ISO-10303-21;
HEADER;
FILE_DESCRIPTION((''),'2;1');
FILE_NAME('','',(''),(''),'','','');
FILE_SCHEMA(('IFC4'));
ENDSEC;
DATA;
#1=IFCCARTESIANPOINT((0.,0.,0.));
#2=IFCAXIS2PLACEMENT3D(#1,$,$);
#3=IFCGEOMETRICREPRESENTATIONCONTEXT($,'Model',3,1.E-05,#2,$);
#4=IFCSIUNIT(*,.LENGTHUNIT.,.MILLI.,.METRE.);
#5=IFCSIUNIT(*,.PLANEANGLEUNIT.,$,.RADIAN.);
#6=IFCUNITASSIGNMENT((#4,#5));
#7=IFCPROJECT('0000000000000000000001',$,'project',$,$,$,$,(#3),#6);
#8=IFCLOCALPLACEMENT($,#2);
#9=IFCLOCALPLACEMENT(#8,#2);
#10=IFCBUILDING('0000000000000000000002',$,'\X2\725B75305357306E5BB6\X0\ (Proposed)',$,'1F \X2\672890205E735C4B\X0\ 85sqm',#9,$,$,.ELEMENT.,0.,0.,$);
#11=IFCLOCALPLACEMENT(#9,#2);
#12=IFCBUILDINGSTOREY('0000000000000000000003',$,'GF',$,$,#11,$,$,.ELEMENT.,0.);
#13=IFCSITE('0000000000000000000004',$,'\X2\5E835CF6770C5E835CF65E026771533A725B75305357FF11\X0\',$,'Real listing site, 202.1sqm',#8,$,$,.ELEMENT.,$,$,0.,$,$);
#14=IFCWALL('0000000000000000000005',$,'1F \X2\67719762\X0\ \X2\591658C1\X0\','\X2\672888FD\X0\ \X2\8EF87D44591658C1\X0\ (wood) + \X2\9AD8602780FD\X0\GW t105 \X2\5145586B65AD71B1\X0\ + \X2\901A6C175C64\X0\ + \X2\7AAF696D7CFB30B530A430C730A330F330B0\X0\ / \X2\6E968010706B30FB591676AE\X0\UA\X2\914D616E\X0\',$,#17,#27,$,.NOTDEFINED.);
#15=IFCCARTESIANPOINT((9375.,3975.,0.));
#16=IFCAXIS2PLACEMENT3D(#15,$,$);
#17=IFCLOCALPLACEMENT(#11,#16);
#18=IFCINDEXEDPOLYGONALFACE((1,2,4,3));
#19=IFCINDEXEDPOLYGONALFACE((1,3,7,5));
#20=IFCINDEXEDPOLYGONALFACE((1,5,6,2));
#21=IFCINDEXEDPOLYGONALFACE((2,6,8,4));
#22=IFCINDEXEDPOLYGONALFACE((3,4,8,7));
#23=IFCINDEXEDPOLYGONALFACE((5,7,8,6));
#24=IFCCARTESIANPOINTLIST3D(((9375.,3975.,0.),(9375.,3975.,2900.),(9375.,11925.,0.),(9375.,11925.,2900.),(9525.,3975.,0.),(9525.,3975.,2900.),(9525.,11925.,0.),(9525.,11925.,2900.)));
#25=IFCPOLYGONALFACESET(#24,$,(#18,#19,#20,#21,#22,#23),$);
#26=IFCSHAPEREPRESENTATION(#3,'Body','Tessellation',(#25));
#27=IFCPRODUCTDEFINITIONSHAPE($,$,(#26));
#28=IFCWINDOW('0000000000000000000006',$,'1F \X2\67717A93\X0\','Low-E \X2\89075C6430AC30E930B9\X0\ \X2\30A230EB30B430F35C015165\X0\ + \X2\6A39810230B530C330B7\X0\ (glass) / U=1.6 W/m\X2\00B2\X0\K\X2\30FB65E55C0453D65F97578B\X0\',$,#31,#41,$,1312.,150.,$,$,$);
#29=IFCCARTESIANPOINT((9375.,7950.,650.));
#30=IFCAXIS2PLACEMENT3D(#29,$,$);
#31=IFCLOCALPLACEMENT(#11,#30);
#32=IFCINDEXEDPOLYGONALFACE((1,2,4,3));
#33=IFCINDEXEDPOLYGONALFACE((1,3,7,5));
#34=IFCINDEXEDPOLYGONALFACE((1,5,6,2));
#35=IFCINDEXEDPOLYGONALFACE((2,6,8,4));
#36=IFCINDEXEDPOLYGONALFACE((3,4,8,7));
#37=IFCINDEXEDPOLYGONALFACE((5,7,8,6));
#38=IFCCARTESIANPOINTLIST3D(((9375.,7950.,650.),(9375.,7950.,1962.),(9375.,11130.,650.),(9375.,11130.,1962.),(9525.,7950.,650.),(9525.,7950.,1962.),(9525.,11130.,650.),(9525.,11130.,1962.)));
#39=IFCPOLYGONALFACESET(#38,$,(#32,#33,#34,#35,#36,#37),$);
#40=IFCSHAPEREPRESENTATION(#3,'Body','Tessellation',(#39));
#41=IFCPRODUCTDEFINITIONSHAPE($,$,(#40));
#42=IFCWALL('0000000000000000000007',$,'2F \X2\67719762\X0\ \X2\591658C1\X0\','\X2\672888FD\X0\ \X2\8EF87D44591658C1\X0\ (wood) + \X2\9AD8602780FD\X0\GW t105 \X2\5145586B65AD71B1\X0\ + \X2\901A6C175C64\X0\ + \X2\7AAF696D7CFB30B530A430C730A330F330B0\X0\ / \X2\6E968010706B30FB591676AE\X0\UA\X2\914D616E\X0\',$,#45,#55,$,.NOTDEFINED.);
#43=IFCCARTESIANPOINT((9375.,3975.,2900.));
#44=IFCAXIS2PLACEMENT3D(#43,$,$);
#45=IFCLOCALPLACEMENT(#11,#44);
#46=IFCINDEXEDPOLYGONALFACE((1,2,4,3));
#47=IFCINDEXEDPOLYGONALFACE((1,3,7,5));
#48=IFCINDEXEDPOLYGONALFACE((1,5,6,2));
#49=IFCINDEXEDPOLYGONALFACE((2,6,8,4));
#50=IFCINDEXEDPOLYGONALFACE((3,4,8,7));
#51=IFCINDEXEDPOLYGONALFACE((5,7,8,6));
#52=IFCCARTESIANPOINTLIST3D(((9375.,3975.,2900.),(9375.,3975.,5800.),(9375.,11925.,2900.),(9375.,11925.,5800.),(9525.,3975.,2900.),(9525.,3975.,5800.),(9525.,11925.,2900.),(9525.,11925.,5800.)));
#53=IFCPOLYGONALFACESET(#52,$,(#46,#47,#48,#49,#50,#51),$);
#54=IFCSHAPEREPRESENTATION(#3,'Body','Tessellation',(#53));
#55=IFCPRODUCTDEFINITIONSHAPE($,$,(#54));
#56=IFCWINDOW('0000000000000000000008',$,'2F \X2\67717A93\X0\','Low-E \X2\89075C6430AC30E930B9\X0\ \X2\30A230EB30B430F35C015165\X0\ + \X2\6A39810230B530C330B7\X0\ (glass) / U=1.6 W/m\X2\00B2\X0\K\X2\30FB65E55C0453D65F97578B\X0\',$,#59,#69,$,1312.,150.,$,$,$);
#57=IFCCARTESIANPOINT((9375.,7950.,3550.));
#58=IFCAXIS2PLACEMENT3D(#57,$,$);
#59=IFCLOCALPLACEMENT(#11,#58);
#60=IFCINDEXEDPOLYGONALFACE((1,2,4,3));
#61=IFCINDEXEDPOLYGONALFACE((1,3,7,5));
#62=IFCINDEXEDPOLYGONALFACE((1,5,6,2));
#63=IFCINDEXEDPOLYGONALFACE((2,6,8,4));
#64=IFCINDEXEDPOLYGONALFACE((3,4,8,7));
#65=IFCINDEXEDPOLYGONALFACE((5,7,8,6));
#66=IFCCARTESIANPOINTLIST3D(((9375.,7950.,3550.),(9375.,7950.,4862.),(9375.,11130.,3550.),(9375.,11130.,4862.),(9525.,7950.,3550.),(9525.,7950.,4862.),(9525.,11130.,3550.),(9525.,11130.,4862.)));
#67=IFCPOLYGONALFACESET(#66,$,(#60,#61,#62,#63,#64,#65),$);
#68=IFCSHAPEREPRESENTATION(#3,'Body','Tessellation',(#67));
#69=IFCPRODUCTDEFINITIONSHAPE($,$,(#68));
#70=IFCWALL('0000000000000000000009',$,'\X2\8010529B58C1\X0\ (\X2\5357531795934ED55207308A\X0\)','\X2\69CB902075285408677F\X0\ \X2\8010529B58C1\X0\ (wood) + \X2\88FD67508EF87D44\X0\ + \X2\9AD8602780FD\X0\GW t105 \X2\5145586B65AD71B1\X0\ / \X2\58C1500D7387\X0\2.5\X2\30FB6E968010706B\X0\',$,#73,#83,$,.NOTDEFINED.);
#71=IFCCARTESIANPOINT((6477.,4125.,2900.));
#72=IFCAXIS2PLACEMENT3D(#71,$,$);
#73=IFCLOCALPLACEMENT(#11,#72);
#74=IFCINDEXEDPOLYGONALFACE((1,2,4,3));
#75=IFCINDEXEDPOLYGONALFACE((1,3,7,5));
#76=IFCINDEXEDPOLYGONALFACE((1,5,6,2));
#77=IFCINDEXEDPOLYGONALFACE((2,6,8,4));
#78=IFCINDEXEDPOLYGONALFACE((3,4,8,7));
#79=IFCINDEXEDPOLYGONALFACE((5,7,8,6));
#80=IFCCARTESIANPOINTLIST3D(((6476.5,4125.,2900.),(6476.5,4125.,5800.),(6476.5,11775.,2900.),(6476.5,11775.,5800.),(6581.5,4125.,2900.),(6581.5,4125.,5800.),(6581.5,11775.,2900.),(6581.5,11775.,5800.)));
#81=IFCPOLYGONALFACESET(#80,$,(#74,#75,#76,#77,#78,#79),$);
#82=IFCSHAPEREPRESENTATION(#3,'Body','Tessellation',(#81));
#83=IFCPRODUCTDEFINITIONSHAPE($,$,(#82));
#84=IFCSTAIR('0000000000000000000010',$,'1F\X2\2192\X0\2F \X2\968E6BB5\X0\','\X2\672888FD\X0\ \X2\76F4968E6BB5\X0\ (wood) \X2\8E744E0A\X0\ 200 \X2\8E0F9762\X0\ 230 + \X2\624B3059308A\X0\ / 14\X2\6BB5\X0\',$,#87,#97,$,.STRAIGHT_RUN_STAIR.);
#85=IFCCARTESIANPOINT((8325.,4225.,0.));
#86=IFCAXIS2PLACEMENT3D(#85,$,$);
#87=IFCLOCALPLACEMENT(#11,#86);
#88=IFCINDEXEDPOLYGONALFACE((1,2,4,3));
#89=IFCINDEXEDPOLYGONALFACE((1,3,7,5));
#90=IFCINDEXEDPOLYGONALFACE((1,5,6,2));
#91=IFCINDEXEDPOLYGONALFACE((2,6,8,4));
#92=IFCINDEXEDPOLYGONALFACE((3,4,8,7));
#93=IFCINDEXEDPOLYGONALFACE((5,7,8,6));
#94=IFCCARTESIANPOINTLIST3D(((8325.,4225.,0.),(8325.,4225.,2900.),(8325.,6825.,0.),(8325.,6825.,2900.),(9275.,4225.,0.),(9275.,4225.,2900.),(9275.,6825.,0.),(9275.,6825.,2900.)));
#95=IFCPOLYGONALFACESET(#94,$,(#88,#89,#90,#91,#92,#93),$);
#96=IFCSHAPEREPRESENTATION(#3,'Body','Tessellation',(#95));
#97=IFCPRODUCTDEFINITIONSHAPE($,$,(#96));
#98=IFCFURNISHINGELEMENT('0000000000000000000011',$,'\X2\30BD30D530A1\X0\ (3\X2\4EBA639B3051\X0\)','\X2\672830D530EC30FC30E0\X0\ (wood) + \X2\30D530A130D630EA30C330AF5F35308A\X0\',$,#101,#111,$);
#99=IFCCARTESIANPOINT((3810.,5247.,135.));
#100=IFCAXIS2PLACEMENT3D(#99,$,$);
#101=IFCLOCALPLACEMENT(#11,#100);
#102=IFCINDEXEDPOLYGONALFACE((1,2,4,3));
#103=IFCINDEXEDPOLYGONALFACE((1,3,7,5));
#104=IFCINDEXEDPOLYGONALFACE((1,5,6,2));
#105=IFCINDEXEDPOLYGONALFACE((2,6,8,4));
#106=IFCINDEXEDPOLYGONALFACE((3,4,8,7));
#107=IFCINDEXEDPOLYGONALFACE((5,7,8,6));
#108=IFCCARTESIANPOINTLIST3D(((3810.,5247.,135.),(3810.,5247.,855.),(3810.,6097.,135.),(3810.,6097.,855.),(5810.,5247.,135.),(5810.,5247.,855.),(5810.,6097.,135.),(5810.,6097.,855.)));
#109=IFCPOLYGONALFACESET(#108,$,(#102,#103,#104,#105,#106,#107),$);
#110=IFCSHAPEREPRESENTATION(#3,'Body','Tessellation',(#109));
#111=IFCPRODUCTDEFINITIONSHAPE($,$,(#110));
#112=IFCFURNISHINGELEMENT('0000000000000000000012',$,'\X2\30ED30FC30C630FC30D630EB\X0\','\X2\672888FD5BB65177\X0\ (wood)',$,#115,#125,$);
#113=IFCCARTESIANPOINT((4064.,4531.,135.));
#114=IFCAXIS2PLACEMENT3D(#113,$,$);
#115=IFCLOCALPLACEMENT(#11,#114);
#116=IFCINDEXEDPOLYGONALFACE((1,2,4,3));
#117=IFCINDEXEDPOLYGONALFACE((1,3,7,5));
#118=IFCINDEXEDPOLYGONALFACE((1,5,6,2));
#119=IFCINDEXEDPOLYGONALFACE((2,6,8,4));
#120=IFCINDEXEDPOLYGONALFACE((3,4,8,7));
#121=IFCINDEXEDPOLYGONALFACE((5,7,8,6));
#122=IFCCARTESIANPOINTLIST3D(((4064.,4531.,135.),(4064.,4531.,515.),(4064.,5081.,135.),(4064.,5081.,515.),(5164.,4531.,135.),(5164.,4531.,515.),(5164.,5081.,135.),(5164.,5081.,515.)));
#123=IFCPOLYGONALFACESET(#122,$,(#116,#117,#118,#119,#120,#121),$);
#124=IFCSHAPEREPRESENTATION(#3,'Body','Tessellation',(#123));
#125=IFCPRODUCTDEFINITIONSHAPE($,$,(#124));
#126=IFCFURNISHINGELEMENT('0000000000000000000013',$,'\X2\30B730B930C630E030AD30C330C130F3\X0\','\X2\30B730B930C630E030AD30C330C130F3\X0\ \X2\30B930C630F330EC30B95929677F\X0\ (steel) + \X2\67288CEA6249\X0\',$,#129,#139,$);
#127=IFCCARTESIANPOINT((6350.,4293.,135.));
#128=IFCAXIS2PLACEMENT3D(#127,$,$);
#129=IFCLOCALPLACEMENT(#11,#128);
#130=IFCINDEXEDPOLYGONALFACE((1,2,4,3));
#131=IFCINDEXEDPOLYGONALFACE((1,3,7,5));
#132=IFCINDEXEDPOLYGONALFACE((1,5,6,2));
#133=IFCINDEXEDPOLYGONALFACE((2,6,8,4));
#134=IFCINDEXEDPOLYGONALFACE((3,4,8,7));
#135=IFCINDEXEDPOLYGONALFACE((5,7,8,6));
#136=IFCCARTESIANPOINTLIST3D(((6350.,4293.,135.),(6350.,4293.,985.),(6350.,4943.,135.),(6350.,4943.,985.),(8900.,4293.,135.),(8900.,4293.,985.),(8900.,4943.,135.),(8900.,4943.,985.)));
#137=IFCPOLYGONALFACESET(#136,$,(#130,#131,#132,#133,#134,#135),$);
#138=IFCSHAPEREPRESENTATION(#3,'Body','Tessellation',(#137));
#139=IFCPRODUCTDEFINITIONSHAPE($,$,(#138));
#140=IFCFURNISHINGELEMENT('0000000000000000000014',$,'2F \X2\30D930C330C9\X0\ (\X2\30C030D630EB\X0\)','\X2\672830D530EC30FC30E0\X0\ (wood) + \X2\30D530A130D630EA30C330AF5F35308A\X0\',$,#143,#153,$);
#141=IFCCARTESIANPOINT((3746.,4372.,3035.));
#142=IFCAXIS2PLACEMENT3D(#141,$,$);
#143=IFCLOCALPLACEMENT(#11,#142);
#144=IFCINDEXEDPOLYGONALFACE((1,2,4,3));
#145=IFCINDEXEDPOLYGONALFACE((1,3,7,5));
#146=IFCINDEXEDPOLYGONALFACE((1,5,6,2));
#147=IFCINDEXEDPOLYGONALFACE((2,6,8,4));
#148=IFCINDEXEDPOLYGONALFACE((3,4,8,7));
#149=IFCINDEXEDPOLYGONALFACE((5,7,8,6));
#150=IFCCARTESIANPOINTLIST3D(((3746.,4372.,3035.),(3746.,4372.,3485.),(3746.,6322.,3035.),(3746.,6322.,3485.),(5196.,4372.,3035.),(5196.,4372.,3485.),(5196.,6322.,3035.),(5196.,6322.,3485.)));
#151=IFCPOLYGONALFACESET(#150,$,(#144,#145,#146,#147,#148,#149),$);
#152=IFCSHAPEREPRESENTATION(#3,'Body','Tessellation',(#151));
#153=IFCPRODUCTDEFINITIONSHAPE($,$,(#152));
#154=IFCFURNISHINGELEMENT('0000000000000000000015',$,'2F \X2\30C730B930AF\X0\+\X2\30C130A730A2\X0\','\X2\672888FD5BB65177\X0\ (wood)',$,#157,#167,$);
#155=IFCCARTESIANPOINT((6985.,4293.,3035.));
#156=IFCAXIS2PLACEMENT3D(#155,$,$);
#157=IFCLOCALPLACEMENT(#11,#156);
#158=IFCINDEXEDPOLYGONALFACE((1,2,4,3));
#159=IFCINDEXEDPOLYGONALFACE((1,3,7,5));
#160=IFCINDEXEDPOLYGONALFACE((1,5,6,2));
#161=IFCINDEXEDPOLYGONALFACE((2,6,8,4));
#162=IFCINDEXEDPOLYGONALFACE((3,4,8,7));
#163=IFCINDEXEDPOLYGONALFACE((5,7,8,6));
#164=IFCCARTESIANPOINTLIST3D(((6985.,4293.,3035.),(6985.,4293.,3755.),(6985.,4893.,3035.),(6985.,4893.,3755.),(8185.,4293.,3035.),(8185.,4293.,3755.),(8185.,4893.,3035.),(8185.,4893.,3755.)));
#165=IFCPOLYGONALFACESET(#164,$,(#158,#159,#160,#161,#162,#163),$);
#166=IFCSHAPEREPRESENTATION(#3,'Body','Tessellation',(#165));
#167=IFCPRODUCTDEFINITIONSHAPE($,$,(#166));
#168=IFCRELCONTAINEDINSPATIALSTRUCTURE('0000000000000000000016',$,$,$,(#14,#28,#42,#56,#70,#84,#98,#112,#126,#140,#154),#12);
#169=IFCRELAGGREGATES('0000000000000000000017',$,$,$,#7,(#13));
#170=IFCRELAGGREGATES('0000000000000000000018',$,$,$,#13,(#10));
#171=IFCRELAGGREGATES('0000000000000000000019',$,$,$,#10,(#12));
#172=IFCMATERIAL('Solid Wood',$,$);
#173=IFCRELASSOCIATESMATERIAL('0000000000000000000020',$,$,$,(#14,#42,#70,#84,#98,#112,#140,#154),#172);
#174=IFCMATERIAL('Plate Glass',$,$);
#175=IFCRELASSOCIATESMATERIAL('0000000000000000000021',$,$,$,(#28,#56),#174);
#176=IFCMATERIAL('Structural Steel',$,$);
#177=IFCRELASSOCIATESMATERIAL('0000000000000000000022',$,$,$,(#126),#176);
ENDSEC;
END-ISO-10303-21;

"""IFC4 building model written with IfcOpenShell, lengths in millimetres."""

from ifc_helpers import new_model, si_unit, frame, frame_2d, origin, place, context, project, spatial, rectangle, extrude, material, element, fill, save


model = new_model("IFC4")

# Units and contexts
model_context = context("Model", 3, precision=1e-05, world=origin())
ifc_project = project(units=[si_unit("LENGTHUNIT", "METRE", prefix="MILLI"), si_unit("PLANEANGLEUNIT", "RADIAN")], contexts=[model_context])

# Site, building, storey
site_placement = place(None, origin())
site = spatial("IfcSite", under=ifc_project, at=site_placement, Name="広島県広島市東区牛田南１", ObjectType="Real listing site, 202.1sqm", CompositionType="ELEMENT", RefElevation=0.0)
building_placement = place(site_placement, origin())
building = spatial("IfcBuilding", under=site, at=building_placement, Name="牛田南の家 (Proposed)", ObjectType="1F 木造平屋 85sqm", CompositionType="ELEMENT", ElevationOfRefHeight=0.0, ElevationOfTerrain=0.0)
storey_placement = place(building_placement, origin())
storey = spatial("IfcBuildingStorey", under=building, at=storey_placement, Name="GF", CompositionType="ELEMENT", Elevation=0.0)

# Wall, opening, window
ifc_material_1 = material(Name="Solid Wood")
wall_1_placement = place(storey_placement, frame((9375.0, 3975.0, 0.0)))
wall_1 = element("IfcWall", 1, at=wall_1_placement, inside=storey, material=ifc_material_1, Name="1F 東面 外壁", Description="木製 軸組外壁 (wood) + 高性能GW t105 充填断熱 + 通気層 + 窯業系サイディング / 準耐火・外皮UA配慮", PredefinedType="NOTDEFINED", context=model_context, shape_type="SweptSolid", body=[
    extrude(rectangle(XDim=150.0, YDim=7950.0, at=frame_2d((75.0, 3975.0))), frame((9375.0, 3975.0, 0.0)), (0.0, 0.0, 1.0), 2900.0),
])
opening_1_placement = place(storey_placement, frame((9375.0, 7950.0, 650.0)))
opening_1 = element("IfcOpeningElement", 2, at=opening_1_placement, cuts=wall_1, PredefinedType="NOTDEFINED", context=model_context, shape_type="SweptSolid", body=[
    extrude(rectangle(XDim=150.0, YDim=3180.0, at=frame_2d((75.0, 1590.0))), frame((9375.0, 7950.0, 650.0)), (0.0, 0.0, 1.0), 1312.0),
])
ifc_material_2 = material(Name="Plate Glass")
window_1_placement = place(storey_placement, frame((9375.0, 7950.0, 650.0)))
window_1 = element("IfcWindow", 3, at=window_1_placement, inside=storey, material=ifc_material_2, Name="1F 東窓", Description="Low-E 複層ガラス アルゴン封入 + 樹脂サッシ (glass) / U=1.6 W/m²K・日射取得型", OverallHeight=1312.0, OverallWidth=150.0, context=model_context, shape_type="SweptSolid", body=[
    extrude(rectangle(XDim=150.0, YDim=3180.0, at=frame_2d((75.0, 1590.0))), frame((9375.0, 7950.0, 650.0)), (0.0, 0.0, 1.0), 1312.0),
])
fill(opening_1, window_1)

# Wall, opening, window
wall_2_placement = place(storey_placement, frame((9375.0, 3975.0, 2900.0)))
wall_2 = element("IfcWall", 4, at=wall_2_placement, inside=storey, material=ifc_material_1, Name="2F 東面 外壁", Description="木製 軸組外壁 (wood) + 高性能GW t105 充填断熱 + 通気層 + 窯業系サイディング / 準耐火・外皮UA配慮", PredefinedType="NOTDEFINED", context=model_context, shape_type="SweptSolid", body=[
    extrude(rectangle(XDim=150.0, YDim=7950.0, at=frame_2d((75.0, 3975.0))), frame((9375.0, 3975.0, 2900.0)), (0.0, 0.0, 1.0), 2900.0),
])
opening_2_placement = place(storey_placement, frame((9375.0, 7950.0, 3550.0)))
opening_2 = element("IfcOpeningElement", 5, at=opening_2_placement, cuts=wall_2, PredefinedType="NOTDEFINED", context=model_context, shape_type="SweptSolid", body=[
    extrude(rectangle(XDim=150.0, YDim=3180.0, at=frame_2d((75.0, 1590.0))), frame((9375.0, 7950.0, 3550.0)), (0.0, 0.0, 1.0), 1312.0),
])
window_2_placement = place(storey_placement, frame((9375.0, 7950.0, 3550.0)))
window_2 = element("IfcWindow", 6, at=window_2_placement, inside=storey, material=ifc_material_2, Name="2F 東窓", Description="Low-E 複層ガラス アルゴン封入 + 樹脂サッシ (glass) / U=1.6 W/m²K・日射取得型", OverallHeight=1312.0, OverallWidth=150.0, context=model_context, shape_type="SweptSolid", body=[
    extrude(rectangle(XDim=150.0, YDim=3180.0, at=frame_2d((75.0, 1590.0))), frame((9375.0, 7950.0, 3550.0)), (0.0, 0.0, 1.0), 1312.0),
])
fill(opening_2, window_2)

# Wall
wall_3_placement = place(storey_placement, frame((6477.0, 4125.0, 2900.0)))
element("IfcWall", 7, at=wall_3_placement, inside=storey, material=ifc_material_1, Name="耐力壁 (南北間仕切り)", Description="構造用合板 耐力壁 (wood) + 製材軸組 + 高性能GW t105 充填断熱 / 壁倍率2.5・準耐火", PredefinedType="NOTDEFINED", context=model_context, shape_type="SweptSolid", body=[
    extrude(rectangle(XDim=105.0, YDim=7650.0, at=frame_2d((52.0, 3825.0))), frame((6477.0, 4125.0, 2900.0)), (0.0, 0.0, 1.0), 2900.0),
])

# Stair
stair_placement = place(storey_placement, frame((8325.0, 4225.0, 0.0)))
element("IfcStair", 8, at=stair_placement, inside=storey, material=ifc_material_1, Name="1F→2F 階段", Description="木製 直階段 (wood) 蹴上 200 踏面 230 + 手すり / 14段", PredefinedType="STRAIGHT_RUN_STAIR", context=model_context, shape_type="SweptSolid", body=[
    extrude(rectangle(XDim=950.0, YDim=2600.0, at=frame_2d((475.0, 1300.0))), frame((8325.0, 4225.0, 0.0)), (0.0, 0.0, 1.0), 2900.0),
])

# Furnishing elements
furnishing_1_placement = place(storey_placement, frame((3810.0, 5247.0, 135.0)))
element("IfcFurnishingElement", 9, at=furnishing_1_placement, inside=storey, material=ifc_material_1, Name="ソファ (3人掛け)", Description="木フレーム (wood) + ファブリック張り", context=model_context, shape_type="SweptSolid", body=[
    extrude(rectangle(XDim=2000.0, YDim=850.0, at=frame_2d((1000.0, 425.0))), frame((3810.0, 5247.0, 135.0)), (0.0, 0.0, 1.0), 720.0),
])
furnishing_2_placement = place(storey_placement, frame((4064.0, 4531.0, 135.0)))
element("IfcFurnishingElement", 10, at=furnishing_2_placement, inside=storey, material=ifc_material_1, Name="ローテーブル", Description="木製家具 (wood)", context=model_context, shape_type="SweptSolid", body=[
    extrude(rectangle(XDim=1100.0, YDim=550.0, at=frame_2d((550.0, 275.0))), frame((4064.0, 4531.0, 135.0)), (0.0, 0.0, 1.0), 380.0),
])
ifc_material_3 = material(Name="Structural Steel")
furnishing_3_placement = place(storey_placement, frame((6350.0, 4293.0, 135.0)))
element("IfcFurnishingElement", 11, at=furnishing_3_placement, inside=storey, material=ifc_material_3, Name="システムキッチン", Description="システムキッチン ステンレス天板 (steel) + 木質扉", context=model_context, shape_type="SweptSolid", body=[
    extrude(rectangle(XDim=2550.0, YDim=650.0, at=frame_2d((1275.0, 325.0))), frame((6350.0, 4293.0, 135.0)), (0.0, 0.0, 1.0), 850.0),
])
furnishing_4_placement = place(storey_placement, frame((3746.0, 4372.0, 3035.0)))
element("IfcFurnishingElement", 12, at=furnishing_4_placement, inside=storey, material=ifc_material_1, Name="2F ベッド (ダブル)", Description="木フレーム (wood) + ファブリック張り", context=model_context, shape_type="SweptSolid", body=[
    extrude(rectangle(XDim=1450.0, YDim=1950.0, at=frame_2d((725.0, 975.0))), frame((3746.0, 4372.0, 3035.0)), (0.0, 0.0, 1.0), 450.0),
])
furnishing_5_placement = place(storey_placement, frame((6985.0, 4293.0, 3035.0)))
element("IfcFurnishingElement", 13, at=furnishing_5_placement, inside=storey, material=ifc_material_1, Name="2F デスク+チェア", Description="木製家具 (wood)", context=model_context, shape_type="SweptSolid", body=[
    extrude(rectangle(XDim=1200.0, YDim=600.0, at=frame_2d((600.0, 300.0))), frame((6985.0, 4293.0, 3035.0)), (0.0, 0.0, 1.0), 720.0),
])

save(model, "model.ifc")
